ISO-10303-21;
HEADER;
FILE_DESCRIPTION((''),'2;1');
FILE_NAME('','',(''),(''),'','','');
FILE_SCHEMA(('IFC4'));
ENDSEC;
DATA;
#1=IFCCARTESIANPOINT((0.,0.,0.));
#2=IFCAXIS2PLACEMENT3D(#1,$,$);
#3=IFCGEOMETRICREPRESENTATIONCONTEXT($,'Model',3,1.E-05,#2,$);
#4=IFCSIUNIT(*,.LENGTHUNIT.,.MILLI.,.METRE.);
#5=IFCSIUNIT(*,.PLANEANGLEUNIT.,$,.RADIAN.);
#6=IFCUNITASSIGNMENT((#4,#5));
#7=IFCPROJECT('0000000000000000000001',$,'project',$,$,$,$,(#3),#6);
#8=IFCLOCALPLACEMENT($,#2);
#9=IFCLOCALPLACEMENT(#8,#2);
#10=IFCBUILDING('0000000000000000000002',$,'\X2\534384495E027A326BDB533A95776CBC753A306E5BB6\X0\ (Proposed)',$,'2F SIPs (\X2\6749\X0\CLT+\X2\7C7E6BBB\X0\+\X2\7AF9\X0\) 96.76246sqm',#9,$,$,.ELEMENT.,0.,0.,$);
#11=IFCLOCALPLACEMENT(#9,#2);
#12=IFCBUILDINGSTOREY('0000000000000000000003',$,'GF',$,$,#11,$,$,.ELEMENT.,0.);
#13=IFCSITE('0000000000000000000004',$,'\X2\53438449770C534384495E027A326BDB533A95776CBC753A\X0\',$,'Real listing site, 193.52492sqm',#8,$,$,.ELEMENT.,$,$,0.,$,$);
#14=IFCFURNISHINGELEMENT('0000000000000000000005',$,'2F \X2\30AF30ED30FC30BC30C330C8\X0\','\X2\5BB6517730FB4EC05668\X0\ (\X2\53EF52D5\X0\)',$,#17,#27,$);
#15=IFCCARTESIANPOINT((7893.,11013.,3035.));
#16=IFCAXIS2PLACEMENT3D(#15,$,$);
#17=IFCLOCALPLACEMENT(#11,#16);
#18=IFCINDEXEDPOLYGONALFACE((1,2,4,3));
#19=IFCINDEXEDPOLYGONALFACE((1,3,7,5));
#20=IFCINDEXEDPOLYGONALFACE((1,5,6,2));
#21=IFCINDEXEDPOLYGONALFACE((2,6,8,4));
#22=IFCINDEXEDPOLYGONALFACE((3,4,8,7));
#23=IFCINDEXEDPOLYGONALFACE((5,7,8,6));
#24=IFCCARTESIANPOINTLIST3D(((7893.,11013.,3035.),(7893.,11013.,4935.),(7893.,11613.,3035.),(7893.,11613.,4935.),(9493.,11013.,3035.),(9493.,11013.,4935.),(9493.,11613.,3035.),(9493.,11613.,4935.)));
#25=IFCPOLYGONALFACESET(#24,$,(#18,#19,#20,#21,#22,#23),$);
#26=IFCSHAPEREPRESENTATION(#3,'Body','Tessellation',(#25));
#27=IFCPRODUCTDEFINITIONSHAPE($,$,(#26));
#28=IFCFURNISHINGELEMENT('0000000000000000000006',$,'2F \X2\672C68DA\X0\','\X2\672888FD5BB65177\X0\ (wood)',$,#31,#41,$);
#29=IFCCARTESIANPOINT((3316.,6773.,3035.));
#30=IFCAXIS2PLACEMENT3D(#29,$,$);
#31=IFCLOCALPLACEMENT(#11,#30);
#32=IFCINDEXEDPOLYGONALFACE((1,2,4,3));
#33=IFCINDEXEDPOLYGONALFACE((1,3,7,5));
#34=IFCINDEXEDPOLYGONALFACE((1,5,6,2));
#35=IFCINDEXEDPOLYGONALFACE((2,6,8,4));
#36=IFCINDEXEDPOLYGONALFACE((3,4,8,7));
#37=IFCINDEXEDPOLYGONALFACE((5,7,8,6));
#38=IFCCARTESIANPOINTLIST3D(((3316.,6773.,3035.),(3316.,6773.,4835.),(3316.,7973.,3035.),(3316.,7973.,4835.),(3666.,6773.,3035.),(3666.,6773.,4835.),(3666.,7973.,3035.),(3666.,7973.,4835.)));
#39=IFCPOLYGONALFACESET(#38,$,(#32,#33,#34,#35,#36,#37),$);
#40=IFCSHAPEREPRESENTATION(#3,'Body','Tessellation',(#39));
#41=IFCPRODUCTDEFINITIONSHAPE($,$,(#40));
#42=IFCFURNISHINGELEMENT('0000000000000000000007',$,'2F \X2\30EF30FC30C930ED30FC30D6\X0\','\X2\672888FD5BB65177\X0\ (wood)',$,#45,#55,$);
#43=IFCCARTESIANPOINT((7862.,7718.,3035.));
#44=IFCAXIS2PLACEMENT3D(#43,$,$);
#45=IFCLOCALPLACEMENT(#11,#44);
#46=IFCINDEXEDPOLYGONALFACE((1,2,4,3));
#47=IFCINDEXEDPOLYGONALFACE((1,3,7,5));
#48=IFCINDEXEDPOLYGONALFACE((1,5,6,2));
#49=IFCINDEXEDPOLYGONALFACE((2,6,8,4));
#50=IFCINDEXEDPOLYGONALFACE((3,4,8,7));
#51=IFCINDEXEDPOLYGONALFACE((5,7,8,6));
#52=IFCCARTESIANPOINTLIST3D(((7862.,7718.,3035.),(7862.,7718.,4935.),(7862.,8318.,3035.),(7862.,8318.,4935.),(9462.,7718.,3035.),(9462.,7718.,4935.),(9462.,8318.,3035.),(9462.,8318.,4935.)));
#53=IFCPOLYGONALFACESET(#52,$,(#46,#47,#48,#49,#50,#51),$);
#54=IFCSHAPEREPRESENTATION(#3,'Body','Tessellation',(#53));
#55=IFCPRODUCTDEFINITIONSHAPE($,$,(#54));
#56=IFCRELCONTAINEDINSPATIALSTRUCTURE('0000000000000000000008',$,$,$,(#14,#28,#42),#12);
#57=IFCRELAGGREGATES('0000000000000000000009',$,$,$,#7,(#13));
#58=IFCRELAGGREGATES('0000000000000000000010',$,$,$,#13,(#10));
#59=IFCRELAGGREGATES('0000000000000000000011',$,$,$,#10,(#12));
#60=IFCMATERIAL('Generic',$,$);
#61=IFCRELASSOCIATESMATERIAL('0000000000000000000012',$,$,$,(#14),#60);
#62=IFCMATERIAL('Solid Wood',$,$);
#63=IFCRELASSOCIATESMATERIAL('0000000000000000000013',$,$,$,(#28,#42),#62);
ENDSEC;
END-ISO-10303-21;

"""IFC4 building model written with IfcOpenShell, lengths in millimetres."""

from ifc_helpers import new_model, si_unit, frame, frame_2d, origin, place, context, project, spatial, rectangle, extrude, material, element, save


model = new_model("IFC4")

# Units and contexts
model_context = context("Model", 3, precision=1e-05, world=origin())
ifc_project = project(units=[si_unit("LENGTHUNIT", "METRE", prefix="MILLI"), si_unit("PLANEANGLEUNIT", "RADIAN")], contexts=[model_context])

# Site, building, storey
site_placement = place(None, origin())
site = spatial("IfcSite", under=ifc_project, at=site_placement, Name="千葉県千葉市稲毛区長沼町", ObjectType="Real listing site, 193.52492sqm", CompositionType="ELEMENT", RefElevation=0.0)
building_placement = place(site_placement, origin())
building = spatial("IfcBuilding", under=site, at=building_placement, Name="千葉市稲毛区長沼町の家 (Proposed)", ObjectType="2F SIPs (杉CLT+籾殻+竹) 96.76246sqm", CompositionType="ELEMENT", ElevationOfRefHeight=0.0, ElevationOfTerrain=0.0)
storey_placement = place(building_placement, origin())
storey = spatial("IfcBuildingStorey", under=building, at=storey_placement, Name="GF", CompositionType="ELEMENT", Elevation=0.0)

# Shared definitions
ifc_material_1 = material(Name="Solid Wood")

# Shared definitions
ifc_material_2 = material(Name="Generic")

# Furnishing elements
furnishing_1_placement = place(storey_placement, frame((7893.0, 11013.0, 3035.0)))
element("IfcFurnishingElement", 1, at=furnishing_1_placement, inside=storey, material=ifc_material_2, Name="2F クローゼット", Description="家具・什器 (可動)", context=model_context, shape_type="SweptSolid", body=[
    extrude(rectangle(XDim=1600.0, YDim=600.0, at=frame_2d((800.0, 300.0))), frame((7893.0, 11013.0, 3035.0)), (0.0, 0.0, 1.0), 1900.0),
])
furnishing_2_placement = place(storey_placement, frame((3316.0, 6773.0, 3035.0)))
element("IfcFurnishingElement", 2, at=furnishing_2_placement, inside=storey, material=ifc_material_1, Name="2F 本棚", Description="木製家具 (wood)", context=model_context, shape_type="SweptSolid", body=[
    extrude(rectangle(XDim=350.0, YDim=1200.0, at=frame_2d((175.0, 600.0))), frame((3316.0, 6773.0, 3035.0)), (0.0, 0.0, 1.0), 1800.0),
])
furnishing_3_placement = place(storey_placement, frame((7862.0, 7718.0, 3035.0)))
element("IfcFurnishingElement", 3, at=furnishing_3_placement, inside=storey, material=ifc_material_1, Name="2F ワードローブ", Description="木製家具 (wood)", context=model_context, shape_type="SweptSolid", body=[
    extrude(rectangle(XDim=1600.0, YDim=600.0, at=frame_2d((800.0, 300.0))), frame((7862.0, 7718.0, 3035.0)), (0.0, 0.0, 1.0), 1900.0),
])

save(model, "model.ifc")
